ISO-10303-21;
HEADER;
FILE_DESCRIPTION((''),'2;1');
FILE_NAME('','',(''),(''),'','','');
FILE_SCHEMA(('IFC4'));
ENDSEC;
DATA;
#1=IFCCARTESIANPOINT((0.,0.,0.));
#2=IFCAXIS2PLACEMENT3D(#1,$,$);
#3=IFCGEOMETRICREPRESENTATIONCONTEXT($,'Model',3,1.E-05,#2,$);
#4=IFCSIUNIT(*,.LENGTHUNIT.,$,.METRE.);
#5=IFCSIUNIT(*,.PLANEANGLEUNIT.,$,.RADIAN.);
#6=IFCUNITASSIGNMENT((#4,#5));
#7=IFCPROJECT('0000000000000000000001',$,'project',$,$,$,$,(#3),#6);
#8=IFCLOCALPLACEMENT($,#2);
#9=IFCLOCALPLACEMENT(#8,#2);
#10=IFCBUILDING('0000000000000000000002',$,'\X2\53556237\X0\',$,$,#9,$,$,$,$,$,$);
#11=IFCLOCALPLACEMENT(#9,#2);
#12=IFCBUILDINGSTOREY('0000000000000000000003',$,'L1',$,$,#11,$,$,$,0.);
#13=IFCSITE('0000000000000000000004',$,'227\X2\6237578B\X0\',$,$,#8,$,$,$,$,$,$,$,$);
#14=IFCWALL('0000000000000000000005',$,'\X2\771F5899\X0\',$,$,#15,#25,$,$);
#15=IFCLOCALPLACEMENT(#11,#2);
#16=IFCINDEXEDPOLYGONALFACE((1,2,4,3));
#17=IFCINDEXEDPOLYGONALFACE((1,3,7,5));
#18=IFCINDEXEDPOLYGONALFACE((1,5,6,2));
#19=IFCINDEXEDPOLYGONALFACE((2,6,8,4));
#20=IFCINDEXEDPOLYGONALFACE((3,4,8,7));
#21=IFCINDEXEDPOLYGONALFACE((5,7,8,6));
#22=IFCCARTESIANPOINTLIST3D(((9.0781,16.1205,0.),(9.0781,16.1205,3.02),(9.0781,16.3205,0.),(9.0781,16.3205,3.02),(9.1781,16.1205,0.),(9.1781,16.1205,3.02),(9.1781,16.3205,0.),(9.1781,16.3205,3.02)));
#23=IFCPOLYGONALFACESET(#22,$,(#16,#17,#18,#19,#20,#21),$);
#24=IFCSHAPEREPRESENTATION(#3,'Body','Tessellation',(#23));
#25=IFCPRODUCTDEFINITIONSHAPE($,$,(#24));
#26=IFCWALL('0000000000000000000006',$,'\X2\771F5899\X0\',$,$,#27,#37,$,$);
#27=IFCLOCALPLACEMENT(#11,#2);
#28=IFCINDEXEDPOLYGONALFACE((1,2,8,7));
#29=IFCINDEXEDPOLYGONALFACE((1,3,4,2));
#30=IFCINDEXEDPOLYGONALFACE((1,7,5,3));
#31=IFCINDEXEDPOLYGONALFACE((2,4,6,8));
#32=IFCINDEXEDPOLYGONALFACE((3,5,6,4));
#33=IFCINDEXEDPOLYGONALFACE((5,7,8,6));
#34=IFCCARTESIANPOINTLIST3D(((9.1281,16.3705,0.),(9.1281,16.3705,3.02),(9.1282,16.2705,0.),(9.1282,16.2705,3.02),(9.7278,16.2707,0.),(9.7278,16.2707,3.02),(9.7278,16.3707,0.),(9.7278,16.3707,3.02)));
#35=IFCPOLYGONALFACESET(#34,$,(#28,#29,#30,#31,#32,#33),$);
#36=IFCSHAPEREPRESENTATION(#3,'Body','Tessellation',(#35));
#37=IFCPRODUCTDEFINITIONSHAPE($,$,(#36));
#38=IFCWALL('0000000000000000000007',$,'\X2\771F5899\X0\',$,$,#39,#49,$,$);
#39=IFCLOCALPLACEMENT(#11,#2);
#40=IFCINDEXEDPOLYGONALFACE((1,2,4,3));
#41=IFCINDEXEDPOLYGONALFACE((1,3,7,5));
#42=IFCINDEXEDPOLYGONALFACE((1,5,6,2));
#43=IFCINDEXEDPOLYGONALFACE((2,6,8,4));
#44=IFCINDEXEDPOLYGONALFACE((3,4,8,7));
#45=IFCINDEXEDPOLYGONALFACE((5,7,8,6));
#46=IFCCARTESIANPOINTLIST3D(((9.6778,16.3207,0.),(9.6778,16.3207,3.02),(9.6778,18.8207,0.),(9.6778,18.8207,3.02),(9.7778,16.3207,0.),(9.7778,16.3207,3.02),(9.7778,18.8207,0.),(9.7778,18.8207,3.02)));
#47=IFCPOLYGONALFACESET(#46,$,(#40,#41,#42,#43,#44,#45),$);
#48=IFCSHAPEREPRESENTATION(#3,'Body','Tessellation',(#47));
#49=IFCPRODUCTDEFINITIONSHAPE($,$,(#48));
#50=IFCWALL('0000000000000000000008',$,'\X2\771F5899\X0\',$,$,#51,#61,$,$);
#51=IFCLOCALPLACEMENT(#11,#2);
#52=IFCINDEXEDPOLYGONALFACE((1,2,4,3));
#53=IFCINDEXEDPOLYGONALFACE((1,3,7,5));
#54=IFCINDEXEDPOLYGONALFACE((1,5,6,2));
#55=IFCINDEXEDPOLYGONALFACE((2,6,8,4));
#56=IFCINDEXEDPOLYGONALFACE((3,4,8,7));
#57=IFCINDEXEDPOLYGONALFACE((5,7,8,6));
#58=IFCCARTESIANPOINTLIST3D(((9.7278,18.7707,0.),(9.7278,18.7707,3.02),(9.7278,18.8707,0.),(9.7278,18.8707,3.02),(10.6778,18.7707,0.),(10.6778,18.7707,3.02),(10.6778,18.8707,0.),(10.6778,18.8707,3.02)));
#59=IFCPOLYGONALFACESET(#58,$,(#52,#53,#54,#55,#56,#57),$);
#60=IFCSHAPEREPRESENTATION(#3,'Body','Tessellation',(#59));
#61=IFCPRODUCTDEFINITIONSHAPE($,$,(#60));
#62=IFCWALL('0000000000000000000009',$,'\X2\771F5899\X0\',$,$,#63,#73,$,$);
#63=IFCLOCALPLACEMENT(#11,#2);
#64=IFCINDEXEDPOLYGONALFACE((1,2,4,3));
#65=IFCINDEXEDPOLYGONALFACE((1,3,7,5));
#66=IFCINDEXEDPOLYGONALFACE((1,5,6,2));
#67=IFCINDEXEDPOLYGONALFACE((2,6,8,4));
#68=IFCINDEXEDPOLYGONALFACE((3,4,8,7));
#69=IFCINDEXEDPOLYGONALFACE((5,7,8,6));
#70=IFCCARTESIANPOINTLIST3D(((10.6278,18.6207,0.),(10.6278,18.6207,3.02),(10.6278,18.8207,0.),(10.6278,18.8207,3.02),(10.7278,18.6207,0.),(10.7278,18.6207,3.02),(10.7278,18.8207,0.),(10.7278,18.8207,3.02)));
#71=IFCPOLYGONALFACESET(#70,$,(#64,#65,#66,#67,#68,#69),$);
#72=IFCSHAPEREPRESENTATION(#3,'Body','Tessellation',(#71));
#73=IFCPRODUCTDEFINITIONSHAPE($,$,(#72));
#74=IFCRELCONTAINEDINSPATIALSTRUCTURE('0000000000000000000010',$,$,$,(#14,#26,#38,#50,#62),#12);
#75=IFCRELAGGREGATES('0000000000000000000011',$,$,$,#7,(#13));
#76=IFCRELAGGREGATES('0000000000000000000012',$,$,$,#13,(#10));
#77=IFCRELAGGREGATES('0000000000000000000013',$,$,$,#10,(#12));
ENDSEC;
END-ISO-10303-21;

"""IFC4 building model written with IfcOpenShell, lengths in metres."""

from ifc_helpers import new_model, si_unit, origin, place, context, project, spatial, polyline, outline, extrude, element, save


model = new_model("IFC4")

# Units and contexts
model_context = context("Model", 3, precision=1e-05, world=origin())
ifc_project = project(units=[si_unit("LENGTHUNIT", "METRE"), si_unit("PLANEANGLEUNIT", "RADIAN")], contexts=[model_context])

# Site, building, storey
site_placement = place(None, origin())
site = spatial("IfcSite", under=ifc_project, at=site_placement, Name="227户型")
building_placement = place(site_placement, origin())
building = spatial("IfcBuilding", under=site, at=building_placement, Name="单户")
storey_placement = place(building_placement, origin())
storey = spatial("IfcBuildingStorey", under=building, at=storey_placement, Name="L1", Elevation=0.0)

# Walls
wall_1_placement = place(storey_placement, origin())
element("IfcWall", 1, at=wall_1_placement, inside=storey, Name="真墙", context=model_context, shape_type="SweptSolid", body=[
    extrude(outline(polyline([(9.0781, 16.1205), (9.0781, 16.3205), (9.1781, 16.3205), (9.1781, 16.1205), (9.0781, 16.1205)])), origin(), (0.0, 0.0, 1.0), 3.02),
])
wall_2_placement = place(storey_placement, origin())
element("IfcWall", 2, at=wall_2_placement, inside=storey, Name="真墙", context=model_context, shape_type="SweptSolid", body=[
    extrude(outline(polyline([(9.1281, 16.3705), (9.7278, 16.3707), (9.7278, 16.2707), (9.1282, 16.2705), (9.1281, 16.3705)])), origin(), (0.0, 0.0, 1.0), 3.02),
])
wall_3_placement = place(storey_placement, origin())
element("IfcWall", 3, at=wall_3_placement, inside=storey, Name="真墙", context=model_context, shape_type="SweptSolid", body=[
    extrude(outline(polyline([(9.6778, 16.3207), (9.6778, 18.8207), (9.7778, 18.8207), (9.7778, 16.3207), (9.6778, 16.3207)])), origin(), (0.0, 0.0, 1.0), 3.02),
])
wall_4_placement = place(storey_placement, origin())
element("IfcWall", 4, at=wall_4_placement, inside=storey, Name="真墙", context=model_context, shape_type="SweptSolid", body=[
    extrude(outline(polyline([(9.7278, 18.8707), (10.6778, 18.8707), (10.6778, 18.7707), (9.7278, 18.7707), (9.7278, 18.8707)])), origin(), (0.0, 0.0, 1.0), 3.02),
])
wall_5_placement = place(storey_placement, origin())
element("IfcWall", 5, at=wall_5_placement, inside=storey, Name="真墙", context=model_context, shape_type="SweptSolid", body=[
    extrude(outline(polyline([(10.7278, 18.8207), (10.7278, 18.6207), (10.6278, 18.6207), (10.6278, 18.8207), (10.7278, 18.8207)])), origin(), (0.0, 0.0, 1.0), 3.02),
])

save(model, "model.ifc")
